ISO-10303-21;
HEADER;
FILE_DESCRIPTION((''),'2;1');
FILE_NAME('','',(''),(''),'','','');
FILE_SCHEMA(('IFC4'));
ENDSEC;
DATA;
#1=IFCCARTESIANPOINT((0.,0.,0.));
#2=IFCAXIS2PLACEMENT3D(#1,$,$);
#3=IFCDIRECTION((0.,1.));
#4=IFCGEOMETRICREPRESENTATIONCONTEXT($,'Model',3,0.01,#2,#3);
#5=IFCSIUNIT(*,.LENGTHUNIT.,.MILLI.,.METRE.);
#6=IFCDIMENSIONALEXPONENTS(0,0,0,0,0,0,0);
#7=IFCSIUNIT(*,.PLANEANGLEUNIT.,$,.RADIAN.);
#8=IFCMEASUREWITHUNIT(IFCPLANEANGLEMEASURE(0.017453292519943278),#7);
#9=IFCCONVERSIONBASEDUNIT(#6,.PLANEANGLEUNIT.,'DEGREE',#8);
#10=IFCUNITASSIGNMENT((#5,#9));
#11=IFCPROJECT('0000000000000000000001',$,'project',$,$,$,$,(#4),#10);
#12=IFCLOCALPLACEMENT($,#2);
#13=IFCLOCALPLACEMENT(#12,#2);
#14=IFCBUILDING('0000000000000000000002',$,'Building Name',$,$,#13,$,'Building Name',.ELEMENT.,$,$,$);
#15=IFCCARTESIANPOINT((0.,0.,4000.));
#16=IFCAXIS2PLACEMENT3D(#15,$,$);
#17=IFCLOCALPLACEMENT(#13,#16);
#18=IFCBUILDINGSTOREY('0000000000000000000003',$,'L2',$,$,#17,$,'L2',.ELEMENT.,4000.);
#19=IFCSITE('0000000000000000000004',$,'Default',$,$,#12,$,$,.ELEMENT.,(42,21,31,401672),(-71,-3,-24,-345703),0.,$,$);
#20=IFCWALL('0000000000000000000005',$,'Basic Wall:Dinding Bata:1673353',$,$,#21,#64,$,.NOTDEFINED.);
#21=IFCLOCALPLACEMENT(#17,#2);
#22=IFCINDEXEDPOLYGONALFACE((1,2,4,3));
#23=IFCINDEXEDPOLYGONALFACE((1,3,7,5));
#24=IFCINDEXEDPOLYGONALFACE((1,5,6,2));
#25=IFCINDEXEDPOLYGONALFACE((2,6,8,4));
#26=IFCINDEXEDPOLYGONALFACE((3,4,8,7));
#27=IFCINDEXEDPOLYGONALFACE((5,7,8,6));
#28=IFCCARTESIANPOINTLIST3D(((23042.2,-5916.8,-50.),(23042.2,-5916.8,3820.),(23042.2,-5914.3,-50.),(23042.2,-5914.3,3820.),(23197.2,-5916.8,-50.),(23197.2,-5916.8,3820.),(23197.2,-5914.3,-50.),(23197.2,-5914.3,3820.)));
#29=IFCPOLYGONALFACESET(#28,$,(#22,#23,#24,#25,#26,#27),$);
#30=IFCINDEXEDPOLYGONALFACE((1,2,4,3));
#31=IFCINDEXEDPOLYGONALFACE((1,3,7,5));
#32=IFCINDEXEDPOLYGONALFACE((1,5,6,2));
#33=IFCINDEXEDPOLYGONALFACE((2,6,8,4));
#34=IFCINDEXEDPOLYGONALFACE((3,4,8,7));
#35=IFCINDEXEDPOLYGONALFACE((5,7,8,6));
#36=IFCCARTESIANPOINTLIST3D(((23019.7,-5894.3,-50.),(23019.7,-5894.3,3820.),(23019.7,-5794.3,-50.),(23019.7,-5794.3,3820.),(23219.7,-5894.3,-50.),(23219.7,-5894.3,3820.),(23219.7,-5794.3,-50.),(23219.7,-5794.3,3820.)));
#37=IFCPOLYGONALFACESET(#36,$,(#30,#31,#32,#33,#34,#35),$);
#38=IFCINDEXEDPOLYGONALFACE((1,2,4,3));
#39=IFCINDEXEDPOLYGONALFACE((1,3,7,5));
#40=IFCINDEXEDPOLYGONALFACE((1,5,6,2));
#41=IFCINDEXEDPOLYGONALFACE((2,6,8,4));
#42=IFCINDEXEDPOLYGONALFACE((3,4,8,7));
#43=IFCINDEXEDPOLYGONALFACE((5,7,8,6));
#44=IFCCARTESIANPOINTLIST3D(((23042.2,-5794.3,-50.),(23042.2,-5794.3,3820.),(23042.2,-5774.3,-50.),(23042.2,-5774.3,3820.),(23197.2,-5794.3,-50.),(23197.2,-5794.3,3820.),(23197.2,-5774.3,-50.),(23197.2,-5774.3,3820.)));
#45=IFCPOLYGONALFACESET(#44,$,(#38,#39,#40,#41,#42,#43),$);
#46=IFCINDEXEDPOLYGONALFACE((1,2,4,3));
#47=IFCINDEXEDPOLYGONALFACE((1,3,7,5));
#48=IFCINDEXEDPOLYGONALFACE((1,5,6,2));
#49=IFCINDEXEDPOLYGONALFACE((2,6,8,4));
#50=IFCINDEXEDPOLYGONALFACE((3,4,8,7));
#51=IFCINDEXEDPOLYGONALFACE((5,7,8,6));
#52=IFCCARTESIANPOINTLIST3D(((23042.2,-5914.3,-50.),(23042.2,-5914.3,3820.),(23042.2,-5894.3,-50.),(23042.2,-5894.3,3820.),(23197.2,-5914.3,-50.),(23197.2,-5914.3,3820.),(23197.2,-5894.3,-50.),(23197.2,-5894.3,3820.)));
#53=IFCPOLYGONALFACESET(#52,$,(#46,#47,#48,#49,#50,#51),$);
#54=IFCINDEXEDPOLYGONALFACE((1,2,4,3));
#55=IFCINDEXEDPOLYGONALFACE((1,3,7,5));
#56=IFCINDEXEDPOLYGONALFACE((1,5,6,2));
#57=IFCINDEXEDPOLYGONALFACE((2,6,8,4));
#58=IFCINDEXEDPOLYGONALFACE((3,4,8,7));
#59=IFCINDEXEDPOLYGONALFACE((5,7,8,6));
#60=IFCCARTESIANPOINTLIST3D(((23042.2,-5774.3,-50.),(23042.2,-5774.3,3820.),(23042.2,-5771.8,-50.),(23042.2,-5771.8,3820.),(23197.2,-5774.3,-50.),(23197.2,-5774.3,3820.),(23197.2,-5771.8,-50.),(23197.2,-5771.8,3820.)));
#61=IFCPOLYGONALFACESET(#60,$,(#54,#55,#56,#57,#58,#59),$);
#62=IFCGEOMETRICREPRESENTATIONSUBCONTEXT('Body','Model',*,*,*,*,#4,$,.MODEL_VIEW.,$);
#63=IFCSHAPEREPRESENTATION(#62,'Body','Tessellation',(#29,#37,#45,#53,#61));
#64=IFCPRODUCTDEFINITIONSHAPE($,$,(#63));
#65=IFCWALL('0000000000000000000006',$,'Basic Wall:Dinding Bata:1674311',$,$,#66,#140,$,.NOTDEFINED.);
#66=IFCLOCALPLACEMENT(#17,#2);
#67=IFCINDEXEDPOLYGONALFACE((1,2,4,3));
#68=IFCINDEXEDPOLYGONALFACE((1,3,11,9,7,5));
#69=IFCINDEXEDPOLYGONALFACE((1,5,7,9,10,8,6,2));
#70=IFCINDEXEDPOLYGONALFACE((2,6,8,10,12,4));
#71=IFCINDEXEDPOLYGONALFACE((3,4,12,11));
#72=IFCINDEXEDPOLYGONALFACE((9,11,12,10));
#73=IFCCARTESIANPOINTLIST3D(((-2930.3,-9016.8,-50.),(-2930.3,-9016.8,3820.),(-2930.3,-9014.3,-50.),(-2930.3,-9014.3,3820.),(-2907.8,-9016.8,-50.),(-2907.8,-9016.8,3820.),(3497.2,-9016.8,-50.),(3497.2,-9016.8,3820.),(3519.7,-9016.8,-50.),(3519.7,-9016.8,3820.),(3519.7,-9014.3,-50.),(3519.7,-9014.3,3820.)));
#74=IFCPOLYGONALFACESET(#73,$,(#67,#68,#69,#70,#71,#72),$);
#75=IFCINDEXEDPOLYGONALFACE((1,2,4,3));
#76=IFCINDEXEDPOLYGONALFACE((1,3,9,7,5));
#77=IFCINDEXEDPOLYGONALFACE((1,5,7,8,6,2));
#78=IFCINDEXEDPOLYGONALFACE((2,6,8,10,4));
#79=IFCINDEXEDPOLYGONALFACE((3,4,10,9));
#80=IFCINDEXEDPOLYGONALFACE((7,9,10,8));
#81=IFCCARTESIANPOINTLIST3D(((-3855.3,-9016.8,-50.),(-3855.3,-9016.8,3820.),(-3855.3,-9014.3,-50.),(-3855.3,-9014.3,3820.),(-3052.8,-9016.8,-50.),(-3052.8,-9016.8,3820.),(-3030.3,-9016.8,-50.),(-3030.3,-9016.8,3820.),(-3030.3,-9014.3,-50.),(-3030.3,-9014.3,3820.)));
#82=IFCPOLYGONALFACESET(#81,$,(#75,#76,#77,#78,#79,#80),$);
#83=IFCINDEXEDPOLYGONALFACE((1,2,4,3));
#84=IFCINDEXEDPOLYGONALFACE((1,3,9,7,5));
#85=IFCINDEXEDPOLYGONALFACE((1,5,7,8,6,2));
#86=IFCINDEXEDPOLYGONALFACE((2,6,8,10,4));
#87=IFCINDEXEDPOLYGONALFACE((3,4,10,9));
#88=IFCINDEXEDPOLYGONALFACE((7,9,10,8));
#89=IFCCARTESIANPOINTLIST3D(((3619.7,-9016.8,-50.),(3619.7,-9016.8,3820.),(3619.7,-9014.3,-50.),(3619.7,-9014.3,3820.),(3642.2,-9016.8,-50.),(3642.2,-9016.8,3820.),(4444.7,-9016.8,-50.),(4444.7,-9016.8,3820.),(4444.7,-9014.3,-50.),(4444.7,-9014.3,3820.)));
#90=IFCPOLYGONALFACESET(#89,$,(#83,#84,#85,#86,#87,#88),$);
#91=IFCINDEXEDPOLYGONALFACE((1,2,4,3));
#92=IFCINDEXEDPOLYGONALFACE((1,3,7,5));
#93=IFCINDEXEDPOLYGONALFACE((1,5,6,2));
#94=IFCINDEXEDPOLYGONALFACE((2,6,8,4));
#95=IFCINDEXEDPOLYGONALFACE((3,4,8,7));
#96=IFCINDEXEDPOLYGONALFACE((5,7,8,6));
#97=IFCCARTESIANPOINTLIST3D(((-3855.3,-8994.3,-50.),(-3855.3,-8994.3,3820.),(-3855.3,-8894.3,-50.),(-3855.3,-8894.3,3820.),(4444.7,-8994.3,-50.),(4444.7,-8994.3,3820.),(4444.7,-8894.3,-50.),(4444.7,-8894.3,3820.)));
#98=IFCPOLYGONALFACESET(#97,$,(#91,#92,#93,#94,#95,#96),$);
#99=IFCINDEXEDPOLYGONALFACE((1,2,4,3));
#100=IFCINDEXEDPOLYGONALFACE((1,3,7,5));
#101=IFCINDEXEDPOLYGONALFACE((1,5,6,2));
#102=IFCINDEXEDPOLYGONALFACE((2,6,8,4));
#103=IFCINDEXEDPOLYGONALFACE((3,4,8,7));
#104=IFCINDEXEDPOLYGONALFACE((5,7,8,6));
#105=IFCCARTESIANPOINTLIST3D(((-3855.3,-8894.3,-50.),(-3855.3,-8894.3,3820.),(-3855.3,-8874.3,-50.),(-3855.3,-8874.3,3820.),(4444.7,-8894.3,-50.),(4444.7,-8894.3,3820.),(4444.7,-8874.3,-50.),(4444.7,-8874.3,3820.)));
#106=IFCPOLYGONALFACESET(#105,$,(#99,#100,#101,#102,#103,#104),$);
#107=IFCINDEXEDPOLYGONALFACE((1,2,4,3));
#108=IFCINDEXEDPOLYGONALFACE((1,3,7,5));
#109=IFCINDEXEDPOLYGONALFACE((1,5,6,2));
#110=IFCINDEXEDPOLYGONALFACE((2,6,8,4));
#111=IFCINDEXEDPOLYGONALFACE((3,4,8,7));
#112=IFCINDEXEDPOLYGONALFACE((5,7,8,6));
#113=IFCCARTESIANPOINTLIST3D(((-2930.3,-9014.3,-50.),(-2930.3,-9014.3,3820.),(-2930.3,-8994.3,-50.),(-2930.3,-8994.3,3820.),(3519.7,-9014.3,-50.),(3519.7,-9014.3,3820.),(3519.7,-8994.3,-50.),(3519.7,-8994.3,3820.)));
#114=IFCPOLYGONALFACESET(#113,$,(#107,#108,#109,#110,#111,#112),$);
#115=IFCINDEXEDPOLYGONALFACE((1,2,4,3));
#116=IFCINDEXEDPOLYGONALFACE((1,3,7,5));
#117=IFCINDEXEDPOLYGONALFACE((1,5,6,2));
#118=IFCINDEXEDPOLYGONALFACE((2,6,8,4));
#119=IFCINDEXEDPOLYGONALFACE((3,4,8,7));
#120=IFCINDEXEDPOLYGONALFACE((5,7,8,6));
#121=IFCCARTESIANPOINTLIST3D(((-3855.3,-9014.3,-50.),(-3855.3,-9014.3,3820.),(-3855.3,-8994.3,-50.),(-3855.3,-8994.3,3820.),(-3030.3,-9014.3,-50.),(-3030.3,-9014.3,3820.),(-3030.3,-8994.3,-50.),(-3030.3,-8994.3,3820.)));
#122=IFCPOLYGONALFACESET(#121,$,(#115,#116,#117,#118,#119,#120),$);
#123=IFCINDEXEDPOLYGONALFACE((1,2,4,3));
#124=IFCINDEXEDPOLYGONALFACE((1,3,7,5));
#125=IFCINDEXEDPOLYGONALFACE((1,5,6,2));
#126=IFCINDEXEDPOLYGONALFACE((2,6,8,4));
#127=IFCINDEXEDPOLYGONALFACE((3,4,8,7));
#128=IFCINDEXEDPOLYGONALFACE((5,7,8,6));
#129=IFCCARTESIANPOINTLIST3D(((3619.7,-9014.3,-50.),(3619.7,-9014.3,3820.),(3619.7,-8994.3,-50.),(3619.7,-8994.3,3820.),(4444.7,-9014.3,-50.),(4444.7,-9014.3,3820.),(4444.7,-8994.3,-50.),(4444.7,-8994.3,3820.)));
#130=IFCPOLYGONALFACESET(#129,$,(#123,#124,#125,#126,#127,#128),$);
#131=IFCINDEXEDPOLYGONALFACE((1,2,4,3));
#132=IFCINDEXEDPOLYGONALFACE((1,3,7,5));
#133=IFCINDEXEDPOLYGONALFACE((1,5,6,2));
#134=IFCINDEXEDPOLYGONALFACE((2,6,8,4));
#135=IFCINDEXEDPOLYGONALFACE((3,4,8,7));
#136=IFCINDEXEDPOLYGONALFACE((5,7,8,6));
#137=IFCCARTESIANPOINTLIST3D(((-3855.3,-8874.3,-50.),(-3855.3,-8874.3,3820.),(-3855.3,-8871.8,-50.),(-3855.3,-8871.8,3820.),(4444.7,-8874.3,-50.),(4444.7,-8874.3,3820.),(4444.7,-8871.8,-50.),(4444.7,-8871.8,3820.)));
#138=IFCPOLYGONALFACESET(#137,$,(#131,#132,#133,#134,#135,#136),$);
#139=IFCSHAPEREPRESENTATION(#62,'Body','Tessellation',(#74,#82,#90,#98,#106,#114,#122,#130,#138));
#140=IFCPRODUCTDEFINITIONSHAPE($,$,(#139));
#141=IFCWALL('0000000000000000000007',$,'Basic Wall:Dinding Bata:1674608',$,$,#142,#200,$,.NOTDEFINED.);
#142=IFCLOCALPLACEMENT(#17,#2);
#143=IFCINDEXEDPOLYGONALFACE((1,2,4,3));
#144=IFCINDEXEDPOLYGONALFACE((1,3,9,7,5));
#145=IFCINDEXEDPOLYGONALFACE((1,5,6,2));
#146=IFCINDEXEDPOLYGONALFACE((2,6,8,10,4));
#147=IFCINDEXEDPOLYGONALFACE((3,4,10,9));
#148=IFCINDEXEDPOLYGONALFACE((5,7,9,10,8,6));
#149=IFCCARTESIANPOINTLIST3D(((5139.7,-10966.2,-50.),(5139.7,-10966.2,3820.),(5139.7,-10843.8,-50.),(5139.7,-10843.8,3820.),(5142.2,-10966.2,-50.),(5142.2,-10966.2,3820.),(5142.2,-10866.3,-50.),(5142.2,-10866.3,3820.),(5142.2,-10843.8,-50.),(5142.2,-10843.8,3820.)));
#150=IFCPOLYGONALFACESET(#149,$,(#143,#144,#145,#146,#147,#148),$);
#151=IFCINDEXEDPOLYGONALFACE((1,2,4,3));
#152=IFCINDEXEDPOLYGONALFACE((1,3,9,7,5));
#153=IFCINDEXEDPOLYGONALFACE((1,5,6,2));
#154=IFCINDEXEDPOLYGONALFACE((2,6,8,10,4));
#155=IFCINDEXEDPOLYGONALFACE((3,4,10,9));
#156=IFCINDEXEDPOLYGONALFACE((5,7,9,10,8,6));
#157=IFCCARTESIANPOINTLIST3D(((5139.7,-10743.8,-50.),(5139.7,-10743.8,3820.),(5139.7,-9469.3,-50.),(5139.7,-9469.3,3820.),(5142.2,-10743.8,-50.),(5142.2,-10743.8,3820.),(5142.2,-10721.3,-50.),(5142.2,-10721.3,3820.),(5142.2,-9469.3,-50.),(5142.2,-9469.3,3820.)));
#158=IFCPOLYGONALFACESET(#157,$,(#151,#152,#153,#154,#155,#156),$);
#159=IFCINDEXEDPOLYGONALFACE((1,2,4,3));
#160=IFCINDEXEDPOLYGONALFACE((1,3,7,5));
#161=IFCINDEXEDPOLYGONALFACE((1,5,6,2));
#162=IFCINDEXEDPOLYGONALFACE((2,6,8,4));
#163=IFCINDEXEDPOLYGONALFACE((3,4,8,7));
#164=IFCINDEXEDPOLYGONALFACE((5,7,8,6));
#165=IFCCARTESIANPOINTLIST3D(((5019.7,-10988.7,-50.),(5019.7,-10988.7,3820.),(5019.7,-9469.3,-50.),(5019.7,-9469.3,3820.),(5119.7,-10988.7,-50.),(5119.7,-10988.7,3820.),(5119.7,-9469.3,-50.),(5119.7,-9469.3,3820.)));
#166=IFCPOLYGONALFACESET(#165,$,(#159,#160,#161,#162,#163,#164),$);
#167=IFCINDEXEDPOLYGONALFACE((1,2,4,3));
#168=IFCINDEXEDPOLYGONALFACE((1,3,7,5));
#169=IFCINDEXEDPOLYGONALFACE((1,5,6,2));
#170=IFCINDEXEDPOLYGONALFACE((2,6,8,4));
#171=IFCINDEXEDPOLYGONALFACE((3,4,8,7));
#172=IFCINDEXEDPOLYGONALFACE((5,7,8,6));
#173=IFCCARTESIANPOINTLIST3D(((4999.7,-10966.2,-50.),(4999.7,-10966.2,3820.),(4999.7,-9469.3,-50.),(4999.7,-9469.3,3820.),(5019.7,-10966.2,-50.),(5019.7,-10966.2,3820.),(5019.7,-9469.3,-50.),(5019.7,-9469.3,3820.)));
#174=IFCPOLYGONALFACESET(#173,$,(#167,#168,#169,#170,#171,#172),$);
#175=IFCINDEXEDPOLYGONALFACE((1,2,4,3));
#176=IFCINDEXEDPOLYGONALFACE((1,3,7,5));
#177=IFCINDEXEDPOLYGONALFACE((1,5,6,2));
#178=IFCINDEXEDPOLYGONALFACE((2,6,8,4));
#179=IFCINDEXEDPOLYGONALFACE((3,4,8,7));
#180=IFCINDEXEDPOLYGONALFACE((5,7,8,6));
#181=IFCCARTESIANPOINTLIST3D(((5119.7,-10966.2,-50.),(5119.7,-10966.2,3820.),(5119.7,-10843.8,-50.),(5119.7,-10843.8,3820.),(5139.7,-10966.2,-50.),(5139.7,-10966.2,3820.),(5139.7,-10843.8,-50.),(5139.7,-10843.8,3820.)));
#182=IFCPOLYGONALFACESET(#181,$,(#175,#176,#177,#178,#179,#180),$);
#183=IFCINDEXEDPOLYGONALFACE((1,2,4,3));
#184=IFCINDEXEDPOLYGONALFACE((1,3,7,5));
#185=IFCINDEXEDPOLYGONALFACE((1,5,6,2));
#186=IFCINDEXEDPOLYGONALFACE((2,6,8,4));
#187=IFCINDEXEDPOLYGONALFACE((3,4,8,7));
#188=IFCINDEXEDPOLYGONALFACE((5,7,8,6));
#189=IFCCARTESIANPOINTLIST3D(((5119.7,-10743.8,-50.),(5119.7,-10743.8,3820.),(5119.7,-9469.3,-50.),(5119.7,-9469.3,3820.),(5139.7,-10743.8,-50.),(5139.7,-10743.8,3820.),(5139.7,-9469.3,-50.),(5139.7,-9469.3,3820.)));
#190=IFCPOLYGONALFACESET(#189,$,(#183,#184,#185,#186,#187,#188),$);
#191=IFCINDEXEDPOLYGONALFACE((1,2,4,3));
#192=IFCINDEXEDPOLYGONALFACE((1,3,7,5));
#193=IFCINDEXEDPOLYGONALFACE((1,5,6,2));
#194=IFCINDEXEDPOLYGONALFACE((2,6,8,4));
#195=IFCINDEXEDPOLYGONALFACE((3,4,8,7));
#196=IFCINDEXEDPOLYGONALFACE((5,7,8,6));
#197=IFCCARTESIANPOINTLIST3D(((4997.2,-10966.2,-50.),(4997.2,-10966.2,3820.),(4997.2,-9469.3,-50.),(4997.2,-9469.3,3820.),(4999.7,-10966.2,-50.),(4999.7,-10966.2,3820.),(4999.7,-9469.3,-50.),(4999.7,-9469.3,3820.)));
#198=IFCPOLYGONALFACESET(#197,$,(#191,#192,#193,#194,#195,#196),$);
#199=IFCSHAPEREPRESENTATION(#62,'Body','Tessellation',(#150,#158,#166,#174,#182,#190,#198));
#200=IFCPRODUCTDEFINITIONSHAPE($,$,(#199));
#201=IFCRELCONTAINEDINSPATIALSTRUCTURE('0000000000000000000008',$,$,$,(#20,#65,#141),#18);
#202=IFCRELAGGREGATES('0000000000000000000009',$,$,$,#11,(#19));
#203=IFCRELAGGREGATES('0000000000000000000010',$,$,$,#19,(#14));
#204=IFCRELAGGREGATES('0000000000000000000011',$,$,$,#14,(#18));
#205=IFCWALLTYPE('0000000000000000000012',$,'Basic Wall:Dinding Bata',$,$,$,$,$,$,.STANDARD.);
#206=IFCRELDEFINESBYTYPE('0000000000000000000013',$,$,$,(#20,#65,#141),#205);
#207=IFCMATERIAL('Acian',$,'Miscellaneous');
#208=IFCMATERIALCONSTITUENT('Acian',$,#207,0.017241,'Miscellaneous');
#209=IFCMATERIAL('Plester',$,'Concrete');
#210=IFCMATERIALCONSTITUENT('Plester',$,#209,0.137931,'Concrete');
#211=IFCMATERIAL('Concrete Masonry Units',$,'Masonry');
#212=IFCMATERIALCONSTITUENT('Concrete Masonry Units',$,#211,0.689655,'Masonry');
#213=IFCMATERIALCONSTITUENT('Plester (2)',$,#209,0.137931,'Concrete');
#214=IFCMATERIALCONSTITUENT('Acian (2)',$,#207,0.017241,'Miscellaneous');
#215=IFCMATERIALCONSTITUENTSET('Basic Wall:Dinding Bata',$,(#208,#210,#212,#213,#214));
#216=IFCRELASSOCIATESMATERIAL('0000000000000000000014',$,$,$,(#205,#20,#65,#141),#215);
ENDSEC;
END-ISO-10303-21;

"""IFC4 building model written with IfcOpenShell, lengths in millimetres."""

from ifc_helpers import new_model, entity, si_unit, converted_unit, direction, frame, origin, place, context, subcontext, project, spatial, indexed_curve, outline, extrude, material, constituent, constituent_set, type_object, element, save


model = new_model("IFC4")

# Units and contexts
model_context = context("Model", 3, precision=0.01, world=origin(), true_north=direction((0.0, 1.0)))
body_context = subcontext(model_context, "Body", "Model", "MODEL_VIEW")
ifc_project = project(units=[si_unit("LENGTHUNIT", "METRE", prefix="MILLI"), converted_unit("PLANEANGLEUNIT", "DEGREE", entity("IfcPlaneAngleMeasure", 0.017453292519943278), si_unit("PLANEANGLEUNIT", "RADIAN"), dimensions=[0, 0, 0, 0, 0, 0, 0])], contexts=[model_context])

# Site, building, storey
site_placement = place(None, origin())
site = spatial("IfcSite", under=ifc_project, at=site_placement, Name="Default", CompositionType="ELEMENT", RefLatitude=(42, 21, 31, 401672), RefLongitude=(-71, -3, -24, -345703), RefElevation=0.0)
building_placement = place(site_placement, origin())
building = spatial("IfcBuilding", under=site, at=building_placement, Name="Building Name", LongName="Building Name", CompositionType="ELEMENT")
storey_placement = place(building_placement, frame((0.0, 0.0, 4000.0)))
storey = spatial("IfcBuildingStorey", under=building, at=storey_placement, Name="L2", LongName="L2", CompositionType="ELEMENT", Elevation=4000.0)

# Walls
ifc_material_1 = material(Name="Acian", Category="Miscellaneous")
ifc_constituent_1 = constituent(ifc_material_1, Name="Acian", Category="Miscellaneous", fraction=0.017241)
ifc_material_2 = material(Name="Plester", Category="Concrete")
ifc_constituent_2 = constituent(ifc_material_2, Name="Plester", Category="Concrete", fraction=0.137931)
ifc_material_3 = material(Name="Concrete Masonry Units", Category="Masonry")
ifc_constituent_3 = constituent(ifc_material_3, Name="Concrete Masonry Units", Category="Masonry", fraction=0.689655)
ifc_constituent_4 = constituent(ifc_material_2, Name="Plester (2)", Category="Concrete", fraction=0.137931)
ifc_constituent_5 = constituent(ifc_material_1, Name="Acian (2)", Category="Miscellaneous", fraction=0.017241)
ifc_constituent_set = constituent_set(constituents=[ifc_constituent_1, ifc_constituent_2, ifc_constituent_3, ifc_constituent_4, ifc_constituent_5], Name="Basic Wall:Dinding Bata")
wall_type = type_object("IfcWallType", Name="Basic Wall:Dinding Bata", PredefinedType="STANDARD", material=ifc_constituent_set)
wall_1_placement = place(storey_placement, frame((23197.2, -5844.3, -50.0), z_axis=(0.0, 0.0, 1.0), x_axis=(-1.0, 0.0, 0.0)))
element("IfcWall", 1, at=wall_1_placement, inside=storey, type_object=wall_type, material=ifc_constituent_set, Name="Basic Wall:Dinding Bata:1673353", PredefinedType="NOTDEFINED", context=body_context, shape_type="SweptSolid", body=[
    extrude(outline(indexed_curve([(-1.3, -77.5), (1.2, -77.5), (1.2, 77.5), (-1.2, 77.5), (-1.3, -77.5)], self_intersect=False)), frame((77.5, 71.2, 0.0), z_axis=(0.0, 0.0, 1.0), x_axis=(0.0, -1.0, 0.0)), (0.0, 0.0, 1.0), 3870.0),
    extrude(outline(indexed_curve([(-100.0, -50.0), (100.0, -50.0), (100.0, 50.0), (-100.0, 50.0), (-100.0, -50.0)], self_intersect=False)), frame((77.5, 0.0, 0.0)), (0.0, 0.0, 1.0), 3870.0),
    extrude(outline(indexed_curve([(-77.5, -10.0), (77.5, -10.0), (77.5, 10.0), (-77.5, 10.0), (-77.5, -10.0)], self_intersect=False)), frame((77.5, -60.0, 0.0)), (0.0, 0.0, 1.0), 3870.0),
    extrude(outline(indexed_curve([(-77.5, -10.0), (77.5, -10.0), (77.5, 10.0), (-77.5, 10.0), (-77.5, -10.0)], self_intersect=False)), frame((77.5, 60.0, 0.0)), (0.0, 0.0, 1.0), 3870.0),
    extrude(outline(indexed_curve([(-1.2, -77.5), (1.2, -77.5), (1.3, 77.5), (-1.2, 77.5), (-1.2, -77.5)], self_intersect=False)), frame((77.5, -71.3, 0.0), z_axis=(0.0, 0.0, 1.0), x_axis=(0.0, 1.0, 0.0)), (0.0, 0.0, 1.0), 3870.0),
])
wall_2_placement = place(storey_placement, frame((4444.7, -8944.3, -50.0), z_axis=(0.0, 0.0, 1.0), x_axis=(-1.0, 0.0, 0.0)))
element("IfcWall", 2, at=wall_2_placement, inside=storey, type_object=wall_type, material=ifc_constituent_set, Name="Basic Wall:Dinding Bata:1674311", PredefinedType="NOTDEFINED", context=body_context, shape_type="SweptSolid", body=[
    extrude(outline(indexed_curve([(3202.5, -0.8), (3225.0, -0.8), (3225.0, 1.7), (-3225.0, 1.7), (-3225.0, -0.8), (-3202.5, -0.8), (3202.5, -0.8)], self_intersect=False)), frame((4150.0, 71.7, 0.0), z_axis=(0.0, 0.0, 1.0), x_axis=(-1.0, 0.0, 0.0)), (0.0, 0.0, 1.0), 3870.0),
    extrude(outline(indexed_curve([(312.0, -1.0), (334.5, -1.0), (334.5, 1.5), (-490.5, 1.5), (-490.5, -1.0), (312.0, -1.0)], self_intersect=False)), frame((7809.5, 71.5, 0.0), z_axis=(0.0, 0.0, 1.0), x_axis=(-1.0, 0.0, 0.0)), (0.0, 0.0, 1.0), 3870.0),
    extrude(outline(indexed_curve([(-490.5, -1.5), (334.5, -1.5), (334.5, 1.0), (312.0, 1.0), (-490.5, 1.0), (-490.5, -1.5)], self_intersect=False)), frame((490.5, 71.5, 0.0)), (0.0, 0.0, 1.0), 3870.0),
    extrude(outline(indexed_curve([(-4150.0, -50.0), (4150.0, -50.0), (4150.0, 50.0), (-4150.0, 50.0), (-4150.0, -50.0)], self_intersect=False)), frame((4150.0, 0.0, 0.0)), (0.0, 0.0, 1.0), 3870.0),
    extrude(outline(indexed_curve([(-4150.0, -10.0), (4150.0, -10.0), (4150.0, 10.0), (-4150.0, 10.0), (-4150.0, -10.0)], self_intersect=False)), frame((4150.0, -60.0, 0.0)), (0.0, 0.0, 1.0), 3870.0),
    extrude(outline(indexed_curve([(-3225.0, -10.0), (3225.0, -10.0), (3225.0, 10.0), (-3225.0, 10.0), (-3225.0, -10.0)], self_intersect=False)), frame((4150.0, 60.0, 0.0)), (0.0, 0.0, 1.0), 3870.0),
    extrude(outline(indexed_curve([(-412.5, -10.0), (412.5, -10.0), (412.5, 10.0), (-412.5, 10.0), (-412.5, -10.0)], self_intersect=False)), frame((7887.5, 60.0, 0.0), z_axis=(0.0, 0.0, 1.0), x_axis=(-1.0, 0.0, 0.0)), (0.0, 0.0, 1.0), 3870.0),
    extrude(outline(indexed_curve([(-412.5, -10.0), (412.5, -10.0), (412.5, 10.0), (-412.5, 10.0), (-412.5, -10.0)], self_intersect=False)), frame((412.5, 60.0, 0.0)), (0.0, 0.0, 1.0), 3870.0),
    extrude(outline(indexed_curve([(-1.3, -4150.0), (1.2, -4150.0), (1.3, 4150.0), (-1.2, 4150.0), (-1.3, -4150.0)], self_intersect=False)), frame((4150.0, -71.3, 0.0), z_axis=(0.0, 0.0, 1.0), x_axis=(0.0, 1.0, 0.0)), (0.0, 0.0, 1.0), 3870.0),
])
wall_3_placement = place(storey_placement, frame((5069.7, -9469.3, -50.0), z_axis=(0.0, 0.0, 1.0), x_axis=(0.0, -1.0, 0.0)))
element("IfcWall", 3, at=wall_3_placement, inside=storey, type_object=wall_type, material=ifc_constituent_set, Name="Basic Wall:Dinding Bata:1674608", PredefinedType="NOTDEFINED", context=body_context, shape_type="SweptSolid", body=[
    extrude(outline(indexed_curve([(31.0, -1.0), (53.5, -1.0), (53.5, 1.5), (-68.9, 1.5), (-68.9, -1.0), (31.0, -1.0)], self_intersect=False)), frame((1428.0, 71.5, 0.0), z_axis=(0.0, 0.0, 1.0), x_axis=(-1.0, 0.0, 0.0)), (0.0, 0.0, 1.0), 3870.0),
    extrude(outline(indexed_curve([(-760.2, -1.5), (514.3, -1.5), (514.3, 1.0), (491.8, 1.0), (-760.2, 1.0), (-760.2, -1.5)], self_intersect=False)), frame((760.2, 71.5, 0.0)), (0.0, 0.0, 1.0), 3870.0),
    extrude(outline(indexed_curve([(-759.7, -50.0), (759.7, -50.0), (759.7, 50.0), (-759.7, 50.0), (-759.7, -50.0)], self_intersect=False)), frame((759.7, 0.0, 0.0)), (0.0, 0.0, 1.0), 3870.0),
    extrude(outline(indexed_curve([(-748.4, -10.0), (748.4, -10.0), (748.4, 10.0), (-748.4, 10.0), (-748.4, -10.0)], self_intersect=False)), frame((748.4, -60.0, 0.0)), (0.0, 0.0, 1.0), 3870.0),
    extrude(outline(indexed_curve([(-61.2, -10.0), (61.2, -10.0), (61.2, 10.0), (-61.2, 10.0), (-61.2, -10.0)], self_intersect=False)), frame((1435.7, 60.0, 0.0), z_axis=(0.0, 0.0, 1.0), x_axis=(-1.0, 0.0, 0.0)), (0.0, 0.0, 1.0), 3870.0),
    extrude(outline(indexed_curve([(-637.3, -10.0), (637.3, -10.0), (637.3, 10.0), (-637.3, 10.0), (-637.3, -10.0)], self_intersect=False)), frame((637.3, 60.0, 0.0)), (0.0, 0.0, 1.0), 3870.0),
    extrude(outline(indexed_curve([(-1.3, -748.4), (1.2, -748.4), (1.3, 748.4), (-1.2, 748.4), (-1.3, -748.4)], self_intersect=False)), frame((748.4, -71.3, 0.0), z_axis=(0.0, 0.0, 1.0), x_axis=(0.0, 1.0, 0.0)), (0.0, 0.0, 1.0), 3870.0),
])

save(model, "model.ifc")
